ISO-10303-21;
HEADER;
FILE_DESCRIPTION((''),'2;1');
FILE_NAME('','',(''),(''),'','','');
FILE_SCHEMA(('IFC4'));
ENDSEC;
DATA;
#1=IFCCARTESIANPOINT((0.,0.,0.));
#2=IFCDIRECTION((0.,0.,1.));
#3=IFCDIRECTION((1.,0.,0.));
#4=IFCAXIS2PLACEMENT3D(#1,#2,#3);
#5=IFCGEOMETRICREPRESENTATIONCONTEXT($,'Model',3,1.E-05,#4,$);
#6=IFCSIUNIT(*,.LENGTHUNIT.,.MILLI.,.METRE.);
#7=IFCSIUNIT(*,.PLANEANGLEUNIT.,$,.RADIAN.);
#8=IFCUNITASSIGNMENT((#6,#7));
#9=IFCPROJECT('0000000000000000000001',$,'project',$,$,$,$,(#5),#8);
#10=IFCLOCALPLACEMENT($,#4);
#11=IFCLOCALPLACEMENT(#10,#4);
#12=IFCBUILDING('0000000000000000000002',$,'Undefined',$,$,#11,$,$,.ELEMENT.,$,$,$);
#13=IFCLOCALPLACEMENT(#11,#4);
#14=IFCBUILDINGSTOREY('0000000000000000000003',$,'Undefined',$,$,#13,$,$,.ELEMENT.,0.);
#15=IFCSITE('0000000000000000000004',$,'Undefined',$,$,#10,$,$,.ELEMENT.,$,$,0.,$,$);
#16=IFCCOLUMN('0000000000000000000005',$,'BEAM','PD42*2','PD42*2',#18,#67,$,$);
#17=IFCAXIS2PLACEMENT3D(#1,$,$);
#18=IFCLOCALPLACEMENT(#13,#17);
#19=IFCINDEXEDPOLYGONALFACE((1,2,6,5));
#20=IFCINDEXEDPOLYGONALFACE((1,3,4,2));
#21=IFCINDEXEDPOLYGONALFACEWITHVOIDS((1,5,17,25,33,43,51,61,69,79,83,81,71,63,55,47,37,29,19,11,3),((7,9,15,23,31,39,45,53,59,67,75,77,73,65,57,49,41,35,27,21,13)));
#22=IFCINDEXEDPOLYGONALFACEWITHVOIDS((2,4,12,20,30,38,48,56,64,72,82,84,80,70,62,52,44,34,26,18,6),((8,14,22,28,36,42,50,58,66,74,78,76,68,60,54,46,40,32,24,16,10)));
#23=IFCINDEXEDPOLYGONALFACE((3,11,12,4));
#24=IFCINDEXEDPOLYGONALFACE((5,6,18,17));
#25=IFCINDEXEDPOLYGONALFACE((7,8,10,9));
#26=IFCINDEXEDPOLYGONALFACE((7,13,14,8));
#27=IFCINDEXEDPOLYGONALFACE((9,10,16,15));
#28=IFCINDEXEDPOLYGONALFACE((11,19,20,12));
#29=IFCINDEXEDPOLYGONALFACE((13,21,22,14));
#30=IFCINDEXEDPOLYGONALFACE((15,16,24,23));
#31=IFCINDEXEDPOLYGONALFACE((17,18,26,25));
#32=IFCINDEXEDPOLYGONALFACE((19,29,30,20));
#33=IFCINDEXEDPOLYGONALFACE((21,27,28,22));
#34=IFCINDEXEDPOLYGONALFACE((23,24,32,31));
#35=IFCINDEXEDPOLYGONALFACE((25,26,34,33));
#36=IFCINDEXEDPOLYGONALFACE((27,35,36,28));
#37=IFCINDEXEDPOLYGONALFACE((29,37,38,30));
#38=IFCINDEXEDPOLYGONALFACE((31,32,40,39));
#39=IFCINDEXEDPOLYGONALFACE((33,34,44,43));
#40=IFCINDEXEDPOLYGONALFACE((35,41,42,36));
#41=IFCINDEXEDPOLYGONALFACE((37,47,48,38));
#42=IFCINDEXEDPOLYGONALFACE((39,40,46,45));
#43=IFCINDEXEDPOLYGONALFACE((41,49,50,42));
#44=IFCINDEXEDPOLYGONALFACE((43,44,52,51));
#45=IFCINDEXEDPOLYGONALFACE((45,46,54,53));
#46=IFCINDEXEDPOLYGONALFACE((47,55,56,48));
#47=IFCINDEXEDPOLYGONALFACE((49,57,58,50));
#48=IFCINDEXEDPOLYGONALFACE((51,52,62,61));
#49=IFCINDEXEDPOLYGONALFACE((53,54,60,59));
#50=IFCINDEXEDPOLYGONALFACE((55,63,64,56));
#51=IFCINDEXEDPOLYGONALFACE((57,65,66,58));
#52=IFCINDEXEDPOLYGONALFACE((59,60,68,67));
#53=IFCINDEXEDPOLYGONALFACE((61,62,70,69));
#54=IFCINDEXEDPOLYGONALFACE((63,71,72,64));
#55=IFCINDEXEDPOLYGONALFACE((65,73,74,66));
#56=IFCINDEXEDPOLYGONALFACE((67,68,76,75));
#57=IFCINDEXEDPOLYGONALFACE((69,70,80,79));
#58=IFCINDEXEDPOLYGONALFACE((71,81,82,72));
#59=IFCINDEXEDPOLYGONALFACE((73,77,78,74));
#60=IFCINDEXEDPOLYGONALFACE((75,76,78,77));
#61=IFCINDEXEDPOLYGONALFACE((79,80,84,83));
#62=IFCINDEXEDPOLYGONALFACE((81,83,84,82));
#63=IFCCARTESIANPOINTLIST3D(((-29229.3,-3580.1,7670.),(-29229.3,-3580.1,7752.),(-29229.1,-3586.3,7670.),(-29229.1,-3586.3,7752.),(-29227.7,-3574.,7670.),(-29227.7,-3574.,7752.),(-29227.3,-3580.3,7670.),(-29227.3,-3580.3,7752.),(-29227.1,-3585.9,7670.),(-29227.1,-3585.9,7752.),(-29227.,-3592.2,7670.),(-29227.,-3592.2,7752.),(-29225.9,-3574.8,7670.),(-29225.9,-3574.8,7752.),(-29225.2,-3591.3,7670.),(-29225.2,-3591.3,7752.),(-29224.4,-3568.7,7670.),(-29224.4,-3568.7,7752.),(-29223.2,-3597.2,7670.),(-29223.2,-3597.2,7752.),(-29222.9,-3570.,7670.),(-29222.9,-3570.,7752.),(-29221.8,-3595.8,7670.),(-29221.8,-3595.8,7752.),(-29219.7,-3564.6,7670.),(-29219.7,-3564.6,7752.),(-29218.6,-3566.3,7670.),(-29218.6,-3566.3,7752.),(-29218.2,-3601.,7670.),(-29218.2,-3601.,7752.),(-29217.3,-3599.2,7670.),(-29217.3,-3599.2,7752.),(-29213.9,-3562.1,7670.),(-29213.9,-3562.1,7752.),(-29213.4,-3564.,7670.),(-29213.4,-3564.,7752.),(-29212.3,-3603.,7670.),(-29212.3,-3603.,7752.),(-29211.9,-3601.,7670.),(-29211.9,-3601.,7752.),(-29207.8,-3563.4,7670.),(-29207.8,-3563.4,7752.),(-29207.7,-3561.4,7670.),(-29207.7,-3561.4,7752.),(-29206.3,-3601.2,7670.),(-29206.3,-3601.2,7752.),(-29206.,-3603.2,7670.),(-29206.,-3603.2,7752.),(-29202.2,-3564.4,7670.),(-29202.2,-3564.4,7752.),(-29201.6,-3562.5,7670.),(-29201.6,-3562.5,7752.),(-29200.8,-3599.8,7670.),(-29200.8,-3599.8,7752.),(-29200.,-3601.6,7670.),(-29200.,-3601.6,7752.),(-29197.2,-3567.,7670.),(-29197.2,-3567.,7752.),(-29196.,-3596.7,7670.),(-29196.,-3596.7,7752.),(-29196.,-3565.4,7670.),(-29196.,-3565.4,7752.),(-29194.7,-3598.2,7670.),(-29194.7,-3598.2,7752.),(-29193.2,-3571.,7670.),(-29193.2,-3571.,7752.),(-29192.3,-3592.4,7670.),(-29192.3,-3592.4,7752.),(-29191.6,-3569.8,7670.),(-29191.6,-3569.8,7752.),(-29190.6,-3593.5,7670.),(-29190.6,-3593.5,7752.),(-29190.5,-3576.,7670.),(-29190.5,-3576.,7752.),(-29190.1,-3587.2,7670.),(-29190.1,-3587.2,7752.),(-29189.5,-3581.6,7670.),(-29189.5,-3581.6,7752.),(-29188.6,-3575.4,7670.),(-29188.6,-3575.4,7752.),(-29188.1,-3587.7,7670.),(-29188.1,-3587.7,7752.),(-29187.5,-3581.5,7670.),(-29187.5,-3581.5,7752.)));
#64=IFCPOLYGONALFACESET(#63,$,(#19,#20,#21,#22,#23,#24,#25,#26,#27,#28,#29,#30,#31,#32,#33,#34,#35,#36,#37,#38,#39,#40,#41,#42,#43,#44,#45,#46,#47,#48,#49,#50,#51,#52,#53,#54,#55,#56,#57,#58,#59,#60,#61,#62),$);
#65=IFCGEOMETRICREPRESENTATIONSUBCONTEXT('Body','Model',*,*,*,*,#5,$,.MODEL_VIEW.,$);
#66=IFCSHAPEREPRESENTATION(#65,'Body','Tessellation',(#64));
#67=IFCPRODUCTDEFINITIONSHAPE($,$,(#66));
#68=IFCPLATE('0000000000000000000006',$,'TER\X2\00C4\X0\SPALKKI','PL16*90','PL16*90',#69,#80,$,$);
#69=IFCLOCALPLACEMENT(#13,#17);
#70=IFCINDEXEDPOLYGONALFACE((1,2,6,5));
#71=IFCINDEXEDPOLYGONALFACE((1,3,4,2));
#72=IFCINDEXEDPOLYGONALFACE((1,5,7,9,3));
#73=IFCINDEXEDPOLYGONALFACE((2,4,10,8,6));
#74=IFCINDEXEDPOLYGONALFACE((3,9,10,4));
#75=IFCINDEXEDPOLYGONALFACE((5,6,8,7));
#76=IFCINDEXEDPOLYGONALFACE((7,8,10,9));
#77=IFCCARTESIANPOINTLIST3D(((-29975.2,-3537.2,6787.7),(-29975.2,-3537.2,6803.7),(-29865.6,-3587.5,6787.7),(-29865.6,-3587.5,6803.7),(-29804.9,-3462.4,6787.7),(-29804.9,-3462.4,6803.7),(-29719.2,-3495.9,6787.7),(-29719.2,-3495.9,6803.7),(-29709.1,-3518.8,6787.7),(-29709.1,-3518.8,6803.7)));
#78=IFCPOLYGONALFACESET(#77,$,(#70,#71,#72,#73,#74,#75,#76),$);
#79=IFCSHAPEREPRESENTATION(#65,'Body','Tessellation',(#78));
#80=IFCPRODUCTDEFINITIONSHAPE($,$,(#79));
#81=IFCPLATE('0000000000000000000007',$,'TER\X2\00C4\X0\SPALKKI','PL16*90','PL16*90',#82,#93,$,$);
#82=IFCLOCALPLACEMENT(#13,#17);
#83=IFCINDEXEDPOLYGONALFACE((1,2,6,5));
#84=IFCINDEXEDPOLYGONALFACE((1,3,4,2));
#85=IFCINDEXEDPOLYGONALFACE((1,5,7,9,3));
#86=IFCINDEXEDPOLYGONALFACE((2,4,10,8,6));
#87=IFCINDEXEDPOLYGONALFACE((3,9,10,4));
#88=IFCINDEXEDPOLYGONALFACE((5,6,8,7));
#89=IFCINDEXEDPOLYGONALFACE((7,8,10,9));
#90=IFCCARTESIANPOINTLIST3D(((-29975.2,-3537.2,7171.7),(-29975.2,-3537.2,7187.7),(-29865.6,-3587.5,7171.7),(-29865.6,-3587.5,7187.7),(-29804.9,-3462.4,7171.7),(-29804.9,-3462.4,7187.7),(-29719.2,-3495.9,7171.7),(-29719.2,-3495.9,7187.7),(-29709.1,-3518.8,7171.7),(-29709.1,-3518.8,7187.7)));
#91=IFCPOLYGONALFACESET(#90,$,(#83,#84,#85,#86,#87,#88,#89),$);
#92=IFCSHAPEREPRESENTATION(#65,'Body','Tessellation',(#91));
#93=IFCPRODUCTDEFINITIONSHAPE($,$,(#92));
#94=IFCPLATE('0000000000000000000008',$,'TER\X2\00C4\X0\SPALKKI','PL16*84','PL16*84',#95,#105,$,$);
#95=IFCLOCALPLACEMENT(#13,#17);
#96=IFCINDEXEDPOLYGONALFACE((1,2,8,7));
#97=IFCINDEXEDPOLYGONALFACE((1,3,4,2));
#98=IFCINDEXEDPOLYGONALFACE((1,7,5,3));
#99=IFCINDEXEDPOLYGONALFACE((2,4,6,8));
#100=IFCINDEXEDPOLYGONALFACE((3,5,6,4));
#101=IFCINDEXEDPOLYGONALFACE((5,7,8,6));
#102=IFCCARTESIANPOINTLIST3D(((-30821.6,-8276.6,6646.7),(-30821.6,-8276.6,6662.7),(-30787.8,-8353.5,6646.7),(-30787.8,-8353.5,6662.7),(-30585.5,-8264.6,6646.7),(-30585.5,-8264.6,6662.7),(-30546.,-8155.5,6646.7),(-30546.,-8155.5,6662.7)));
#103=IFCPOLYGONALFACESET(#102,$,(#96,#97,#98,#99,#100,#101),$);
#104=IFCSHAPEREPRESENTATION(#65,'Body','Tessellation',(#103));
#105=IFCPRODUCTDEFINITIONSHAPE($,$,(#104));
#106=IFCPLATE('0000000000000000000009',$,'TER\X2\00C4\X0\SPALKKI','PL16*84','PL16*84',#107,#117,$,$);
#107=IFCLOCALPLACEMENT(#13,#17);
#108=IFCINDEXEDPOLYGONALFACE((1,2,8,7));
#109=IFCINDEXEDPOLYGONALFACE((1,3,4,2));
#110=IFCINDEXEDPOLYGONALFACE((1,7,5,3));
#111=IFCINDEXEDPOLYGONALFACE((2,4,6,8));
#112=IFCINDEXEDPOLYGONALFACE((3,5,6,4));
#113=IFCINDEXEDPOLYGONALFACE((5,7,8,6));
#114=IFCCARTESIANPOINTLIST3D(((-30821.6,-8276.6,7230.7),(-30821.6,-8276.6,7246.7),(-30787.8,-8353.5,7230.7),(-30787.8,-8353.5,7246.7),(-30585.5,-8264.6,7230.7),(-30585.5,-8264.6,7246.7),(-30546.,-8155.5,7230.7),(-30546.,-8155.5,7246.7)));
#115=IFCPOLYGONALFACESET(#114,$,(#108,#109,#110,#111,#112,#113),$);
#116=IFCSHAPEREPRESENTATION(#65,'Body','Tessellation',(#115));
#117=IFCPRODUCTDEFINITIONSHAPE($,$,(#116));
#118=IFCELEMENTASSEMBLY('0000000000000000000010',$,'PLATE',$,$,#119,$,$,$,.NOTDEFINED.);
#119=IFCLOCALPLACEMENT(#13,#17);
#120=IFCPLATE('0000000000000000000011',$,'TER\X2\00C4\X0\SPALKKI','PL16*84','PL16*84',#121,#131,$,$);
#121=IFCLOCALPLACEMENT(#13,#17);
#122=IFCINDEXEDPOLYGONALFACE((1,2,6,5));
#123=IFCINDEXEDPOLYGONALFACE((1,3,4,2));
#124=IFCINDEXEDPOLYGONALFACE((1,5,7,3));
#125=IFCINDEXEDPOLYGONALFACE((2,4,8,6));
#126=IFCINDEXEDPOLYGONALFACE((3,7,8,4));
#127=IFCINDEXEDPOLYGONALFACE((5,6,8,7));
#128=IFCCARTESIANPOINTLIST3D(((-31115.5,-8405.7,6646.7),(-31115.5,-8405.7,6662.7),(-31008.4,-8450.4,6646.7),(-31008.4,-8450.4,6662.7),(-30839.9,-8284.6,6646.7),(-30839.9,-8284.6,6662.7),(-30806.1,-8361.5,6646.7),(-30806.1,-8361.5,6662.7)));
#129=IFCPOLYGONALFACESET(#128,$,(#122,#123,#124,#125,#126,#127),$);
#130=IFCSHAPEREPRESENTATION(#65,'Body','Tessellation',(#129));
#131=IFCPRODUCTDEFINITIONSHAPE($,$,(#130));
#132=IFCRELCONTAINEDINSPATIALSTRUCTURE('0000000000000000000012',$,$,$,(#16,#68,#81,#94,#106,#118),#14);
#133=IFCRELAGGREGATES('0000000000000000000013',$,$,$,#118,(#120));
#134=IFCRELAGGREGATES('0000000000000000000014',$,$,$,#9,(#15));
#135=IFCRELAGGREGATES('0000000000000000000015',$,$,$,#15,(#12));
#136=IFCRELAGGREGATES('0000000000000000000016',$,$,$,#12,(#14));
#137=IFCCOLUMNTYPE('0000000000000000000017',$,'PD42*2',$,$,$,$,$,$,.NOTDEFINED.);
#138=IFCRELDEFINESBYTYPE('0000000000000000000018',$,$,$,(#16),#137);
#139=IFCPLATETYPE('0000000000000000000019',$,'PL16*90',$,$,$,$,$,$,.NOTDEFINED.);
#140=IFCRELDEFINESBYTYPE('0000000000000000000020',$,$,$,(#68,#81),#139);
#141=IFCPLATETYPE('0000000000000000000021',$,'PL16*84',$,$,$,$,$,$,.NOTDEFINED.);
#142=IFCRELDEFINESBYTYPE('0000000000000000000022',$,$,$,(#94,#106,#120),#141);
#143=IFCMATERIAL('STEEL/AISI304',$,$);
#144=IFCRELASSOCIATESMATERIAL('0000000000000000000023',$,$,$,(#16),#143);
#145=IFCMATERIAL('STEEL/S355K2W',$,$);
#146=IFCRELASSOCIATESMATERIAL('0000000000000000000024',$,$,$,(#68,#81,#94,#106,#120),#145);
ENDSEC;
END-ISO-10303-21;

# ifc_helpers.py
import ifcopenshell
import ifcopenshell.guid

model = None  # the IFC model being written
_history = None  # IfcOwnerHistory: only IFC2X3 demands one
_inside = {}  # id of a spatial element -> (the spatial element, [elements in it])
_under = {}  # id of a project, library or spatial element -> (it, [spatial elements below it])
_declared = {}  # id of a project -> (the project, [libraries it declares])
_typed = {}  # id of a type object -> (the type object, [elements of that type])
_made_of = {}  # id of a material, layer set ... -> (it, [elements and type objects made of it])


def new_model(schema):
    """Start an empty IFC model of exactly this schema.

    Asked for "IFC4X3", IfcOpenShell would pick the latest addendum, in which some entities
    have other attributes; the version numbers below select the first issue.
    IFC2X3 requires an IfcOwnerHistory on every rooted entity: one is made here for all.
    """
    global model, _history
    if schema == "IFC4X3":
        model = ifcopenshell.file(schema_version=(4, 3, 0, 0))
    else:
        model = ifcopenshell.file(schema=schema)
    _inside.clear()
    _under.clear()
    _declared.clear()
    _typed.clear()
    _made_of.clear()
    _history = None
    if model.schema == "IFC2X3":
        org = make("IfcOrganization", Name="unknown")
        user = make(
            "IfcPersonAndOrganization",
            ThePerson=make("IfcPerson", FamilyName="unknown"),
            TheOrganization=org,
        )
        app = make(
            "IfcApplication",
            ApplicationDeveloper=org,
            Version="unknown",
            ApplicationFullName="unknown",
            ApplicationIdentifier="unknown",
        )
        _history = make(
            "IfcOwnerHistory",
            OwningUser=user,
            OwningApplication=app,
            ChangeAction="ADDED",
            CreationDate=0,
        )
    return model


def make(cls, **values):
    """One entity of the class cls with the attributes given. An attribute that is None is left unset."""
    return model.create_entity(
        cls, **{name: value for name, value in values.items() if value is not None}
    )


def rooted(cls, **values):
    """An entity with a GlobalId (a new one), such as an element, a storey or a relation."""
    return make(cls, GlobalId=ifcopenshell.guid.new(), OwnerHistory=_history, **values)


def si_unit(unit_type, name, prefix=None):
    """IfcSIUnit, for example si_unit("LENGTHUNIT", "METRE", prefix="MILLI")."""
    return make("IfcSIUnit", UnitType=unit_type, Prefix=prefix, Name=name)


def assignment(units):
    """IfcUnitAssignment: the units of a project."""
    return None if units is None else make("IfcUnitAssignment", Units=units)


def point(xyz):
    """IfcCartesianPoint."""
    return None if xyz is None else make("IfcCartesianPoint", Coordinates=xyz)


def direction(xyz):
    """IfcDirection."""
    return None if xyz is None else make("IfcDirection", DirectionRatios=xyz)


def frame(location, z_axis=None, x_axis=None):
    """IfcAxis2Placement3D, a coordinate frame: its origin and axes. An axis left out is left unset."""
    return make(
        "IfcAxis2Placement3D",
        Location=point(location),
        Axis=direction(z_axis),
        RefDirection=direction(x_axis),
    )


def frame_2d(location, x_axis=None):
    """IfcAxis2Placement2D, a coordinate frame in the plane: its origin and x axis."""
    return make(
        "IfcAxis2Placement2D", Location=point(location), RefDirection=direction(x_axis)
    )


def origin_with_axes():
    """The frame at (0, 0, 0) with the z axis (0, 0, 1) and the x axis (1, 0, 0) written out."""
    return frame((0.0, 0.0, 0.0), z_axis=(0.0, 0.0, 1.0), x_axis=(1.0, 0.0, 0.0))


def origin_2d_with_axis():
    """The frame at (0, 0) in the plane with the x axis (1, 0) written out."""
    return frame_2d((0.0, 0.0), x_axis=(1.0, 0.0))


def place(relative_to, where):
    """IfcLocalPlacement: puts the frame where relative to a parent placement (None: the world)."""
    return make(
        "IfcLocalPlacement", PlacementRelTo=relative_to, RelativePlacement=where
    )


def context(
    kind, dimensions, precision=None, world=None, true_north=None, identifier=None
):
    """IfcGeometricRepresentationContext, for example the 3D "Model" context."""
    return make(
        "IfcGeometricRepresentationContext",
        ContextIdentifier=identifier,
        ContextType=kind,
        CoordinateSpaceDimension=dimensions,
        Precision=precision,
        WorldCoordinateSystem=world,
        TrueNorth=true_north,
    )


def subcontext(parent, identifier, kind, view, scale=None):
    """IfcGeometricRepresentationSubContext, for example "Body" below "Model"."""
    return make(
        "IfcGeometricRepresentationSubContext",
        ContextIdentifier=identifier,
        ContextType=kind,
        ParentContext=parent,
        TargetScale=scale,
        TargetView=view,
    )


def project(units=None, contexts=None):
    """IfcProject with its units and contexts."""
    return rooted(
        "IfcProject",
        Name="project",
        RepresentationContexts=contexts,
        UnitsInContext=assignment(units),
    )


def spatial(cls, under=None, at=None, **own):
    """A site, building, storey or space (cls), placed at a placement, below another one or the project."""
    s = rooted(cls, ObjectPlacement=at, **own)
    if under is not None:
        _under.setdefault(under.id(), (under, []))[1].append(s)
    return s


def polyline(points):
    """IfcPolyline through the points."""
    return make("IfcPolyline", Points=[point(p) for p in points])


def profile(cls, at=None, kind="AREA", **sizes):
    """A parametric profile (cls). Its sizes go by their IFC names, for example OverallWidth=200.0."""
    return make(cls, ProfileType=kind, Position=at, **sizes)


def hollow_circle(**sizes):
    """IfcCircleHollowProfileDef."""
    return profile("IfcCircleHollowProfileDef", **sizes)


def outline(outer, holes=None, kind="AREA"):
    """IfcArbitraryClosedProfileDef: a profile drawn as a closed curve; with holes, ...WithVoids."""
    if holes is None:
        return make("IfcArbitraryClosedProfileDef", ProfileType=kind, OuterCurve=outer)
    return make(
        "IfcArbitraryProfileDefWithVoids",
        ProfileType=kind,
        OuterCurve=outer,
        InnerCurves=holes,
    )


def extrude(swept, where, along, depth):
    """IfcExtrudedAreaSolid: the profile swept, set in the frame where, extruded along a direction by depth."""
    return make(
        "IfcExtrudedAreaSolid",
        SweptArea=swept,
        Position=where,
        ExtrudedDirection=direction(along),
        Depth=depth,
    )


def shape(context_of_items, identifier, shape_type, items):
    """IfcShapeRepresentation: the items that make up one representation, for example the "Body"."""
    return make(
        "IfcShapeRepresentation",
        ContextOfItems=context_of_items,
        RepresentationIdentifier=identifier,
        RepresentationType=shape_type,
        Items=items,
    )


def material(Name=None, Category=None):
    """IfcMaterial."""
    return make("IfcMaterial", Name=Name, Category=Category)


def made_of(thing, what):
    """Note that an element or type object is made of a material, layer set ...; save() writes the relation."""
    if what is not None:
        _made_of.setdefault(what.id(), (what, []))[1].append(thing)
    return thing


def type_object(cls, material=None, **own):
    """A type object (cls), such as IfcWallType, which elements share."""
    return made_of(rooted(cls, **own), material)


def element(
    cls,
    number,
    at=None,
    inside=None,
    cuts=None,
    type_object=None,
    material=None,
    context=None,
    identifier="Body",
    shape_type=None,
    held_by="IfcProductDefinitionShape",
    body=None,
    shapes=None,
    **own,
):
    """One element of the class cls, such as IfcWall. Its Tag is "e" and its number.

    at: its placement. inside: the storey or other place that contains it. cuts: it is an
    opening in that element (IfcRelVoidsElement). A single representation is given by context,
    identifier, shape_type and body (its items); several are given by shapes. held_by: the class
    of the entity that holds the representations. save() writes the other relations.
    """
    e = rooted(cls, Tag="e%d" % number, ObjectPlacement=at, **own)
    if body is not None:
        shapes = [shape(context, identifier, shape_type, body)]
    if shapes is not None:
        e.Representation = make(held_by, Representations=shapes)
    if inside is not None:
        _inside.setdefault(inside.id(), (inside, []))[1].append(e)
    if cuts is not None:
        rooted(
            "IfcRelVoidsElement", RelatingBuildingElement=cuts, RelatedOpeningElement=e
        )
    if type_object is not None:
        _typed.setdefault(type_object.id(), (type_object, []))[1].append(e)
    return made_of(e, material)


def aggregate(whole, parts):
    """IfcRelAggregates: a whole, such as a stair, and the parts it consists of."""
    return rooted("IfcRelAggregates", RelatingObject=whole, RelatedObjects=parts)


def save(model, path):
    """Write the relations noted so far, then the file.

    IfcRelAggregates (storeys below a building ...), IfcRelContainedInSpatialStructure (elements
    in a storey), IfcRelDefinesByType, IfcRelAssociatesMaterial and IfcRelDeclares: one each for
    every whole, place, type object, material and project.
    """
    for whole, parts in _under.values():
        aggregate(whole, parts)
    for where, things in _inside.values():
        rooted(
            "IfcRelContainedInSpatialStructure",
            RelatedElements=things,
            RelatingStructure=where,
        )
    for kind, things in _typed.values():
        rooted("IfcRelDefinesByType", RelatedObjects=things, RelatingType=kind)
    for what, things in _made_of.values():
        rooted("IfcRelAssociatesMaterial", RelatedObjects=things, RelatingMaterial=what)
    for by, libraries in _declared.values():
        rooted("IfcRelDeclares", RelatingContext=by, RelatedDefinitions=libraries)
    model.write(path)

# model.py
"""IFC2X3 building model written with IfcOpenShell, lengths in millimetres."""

from ifc_helpers import new_model, si_unit, frame, origin_with_axes, origin_2d_with_axis, place, context, subcontext, project, spatial, polyline, hollow_circle, outline, extrude, material, type_object, element, aggregate, save


model = new_model("IFC2X3")

# Units and contexts
model_context = context("Model", 3, precision=1e-05, world=origin_with_axes())
body_context = subcontext(model_context, "Body", "Model", "MODEL_VIEW")
ifc_project = project(units=[si_unit("LENGTHUNIT", "METRE", prefix="MILLI"), si_unit("PLANEANGLEUNIT", "RADIAN")], contexts=[model_context])

# Site, building, storey
site_placement = place(None, origin_with_axes())
site = spatial("IfcSite", under=ifc_project, at=site_placement, Name="Undefined", CompositionType="ELEMENT", RefElevation=0.0)
building_placement = place(site_placement, origin_with_axes())
building = spatial("IfcBuilding", under=site, at=building_placement, Name="Undefined", CompositionType="ELEMENT")
storey_placement = place(building_placement, origin_with_axes())
storey = spatial("IfcBuildingStorey", under=building, at=storey_placement, Name="Undefined", CompositionType="ELEMENT", Elevation=0.0)

# Column
ifc_material_1 = material(Name="STEEL/AISI304")
column_type_1 = type_object("IfcColumnType", Name="PD42*2", PredefinedType="NOTDEFINED")
column_1_placement = place(storey_placement, frame((-29208.4, -3582.4, 7670.0), z_axis=(0.0, 0.0, 1.0), x_axis=(1.0, 0.0, 0.0)))
element("IfcColumn", 1, at=column_1_placement, inside=storey, type_object=column_type_1, material=ifc_material_1, Name="BEAM", Description="PD42*2", ObjectType="PD42*2", context=body_context, shape_type="SweptSolid", body=[
    extrude(hollow_circle(Radius=21.0, WallThickness=2.0, at=origin_2d_with_axis()), frame((0.0, 0.0, 82.0), z_axis=(0.0, 0.0, -1.0), x_axis=(0.402197, -0.915553, 0.0)), (0.0, 0.0, 1.0), 82.0),
])

# Shared definitions
ifc_material_2 = material(Name="STEEL/S355K2W")

# Plates
plate_type_1 = type_object("IfcPlateType", Name="PL16*90", PredefinedType="NOTDEFINED")
for number, where, z_axis, x_axis, name in (
    (2, (-29719.2, -3495.9, 6795.7), (0.0, 0.0, -1.0), (0.402212, -0.915547, 0.0), "TERÄSPALKKI"),
    (3, (-29719.2, -3495.9, 7179.7), (0.0, 0.0, -1.0), (0.402212, -0.915547, 0.0), "TERÄSPALKKI"),
):
    element("IfcPlate", number, at=place(storey_placement, frame(where, z_axis=z_axis, x_axis=x_axis)), inside=storey, type_object=plate_type_1, material=ifc_material_2, Name=name, Description="PL16*90", ObjectType="PL16*90", context=body_context, shape_type="SweptSolid", body=[
        extrude(outline(polyline([(0.0, 0.0), (25.0, 0.0), (25.0, 171.0), (-65.1, 251.0), (-65.1, 65.0), (0.0, 0.0)])), frame((0.0, 0.0, -8.0), z_axis=(0.0, 0.0, 1.0), x_axis=(1.0, 0.0, 0.0)), (0.0, 0.0, 1.0), 16.0),
    ])
plate_type_2 = type_object("IfcPlateType", Name="PL16*84", PredefinedType="NOTDEFINED")
for number, where, z_axis, x_axis, name in (
    (4, (-30787.8, -8353.5, 6654.7), (0.0, 0.0, 1.0), (0.915555, 0.402194, 0.0), "TERÄSPALKKI"),
    (5, (-30787.8, -8353.5, 7238.7), (0.0, 0.0, 1.0), (0.915555, 0.402194, 0.0), "TERÄSPALKKI"),
):
    element("IfcPlate", number, at=place(storey_placement, frame(where, z_axis=z_axis, x_axis=x_axis)), inside=storey, type_object=plate_type_2, material=ifc_material_2, Name=name, Description="PL16*84", ObjectType="PL16*84", context=body_context, shape_type="SweptSolid", body=[
        extrude(outline(polyline([(0.0, 0.0), (221.0, 0.0), (301.0, 84.0), (0.0, 84.0), (0.0, 0.0)])), frame((0.0, 0.0, -8.0), z_axis=(0.0, 0.0, 1.0), x_axis=(1.0, 0.0, 0.0)), (0.0, 0.0, 1.0), 16.0),
    ])

# Element assembly, plate
assembly_1_placement = place(storey_placement, frame((-30806.1, -8361.5, 6654.7), z_axis=(-0.402202, 0.915551, 0.0), x_axis=(-0.915551, -0.402202, 0.0)))
assembly_1 = element("IfcElementAssembly", 6, at=assembly_1_placement, inside=storey, Name="PLATE", PredefinedType="NOTDEFINED")
plate_placement = place(storey_placement, frame((-30806.1, -8361.5, 6654.7), z_axis=(0.0, 0.0, -1.0), x_axis=(-0.915551, -0.402202, 0.0)))
plate = element("IfcPlate", 7, at=plate_placement, type_object=plate_type_2, material=ifc_material_2, Name="TERÄSPALKKI", Description="PL16*84", ObjectType="PL16*84", context=body_context, shape_type="SweptSolid", body=[
    extrude(outline(polyline([(0.0, 0.0), (221.0, 0.0), (301.0, 84.0), (0.0, 84.0), (0.0, 0.0)])), frame((0.0, 0.0, -8.0), z_axis=(0.0, 0.0, 1.0), x_axis=(1.0, 0.0, 0.0)), (0.0, 0.0, 1.0), 16.0),
])
aggregate(assembly_1, [plate])

save(model, "model.ifc")
